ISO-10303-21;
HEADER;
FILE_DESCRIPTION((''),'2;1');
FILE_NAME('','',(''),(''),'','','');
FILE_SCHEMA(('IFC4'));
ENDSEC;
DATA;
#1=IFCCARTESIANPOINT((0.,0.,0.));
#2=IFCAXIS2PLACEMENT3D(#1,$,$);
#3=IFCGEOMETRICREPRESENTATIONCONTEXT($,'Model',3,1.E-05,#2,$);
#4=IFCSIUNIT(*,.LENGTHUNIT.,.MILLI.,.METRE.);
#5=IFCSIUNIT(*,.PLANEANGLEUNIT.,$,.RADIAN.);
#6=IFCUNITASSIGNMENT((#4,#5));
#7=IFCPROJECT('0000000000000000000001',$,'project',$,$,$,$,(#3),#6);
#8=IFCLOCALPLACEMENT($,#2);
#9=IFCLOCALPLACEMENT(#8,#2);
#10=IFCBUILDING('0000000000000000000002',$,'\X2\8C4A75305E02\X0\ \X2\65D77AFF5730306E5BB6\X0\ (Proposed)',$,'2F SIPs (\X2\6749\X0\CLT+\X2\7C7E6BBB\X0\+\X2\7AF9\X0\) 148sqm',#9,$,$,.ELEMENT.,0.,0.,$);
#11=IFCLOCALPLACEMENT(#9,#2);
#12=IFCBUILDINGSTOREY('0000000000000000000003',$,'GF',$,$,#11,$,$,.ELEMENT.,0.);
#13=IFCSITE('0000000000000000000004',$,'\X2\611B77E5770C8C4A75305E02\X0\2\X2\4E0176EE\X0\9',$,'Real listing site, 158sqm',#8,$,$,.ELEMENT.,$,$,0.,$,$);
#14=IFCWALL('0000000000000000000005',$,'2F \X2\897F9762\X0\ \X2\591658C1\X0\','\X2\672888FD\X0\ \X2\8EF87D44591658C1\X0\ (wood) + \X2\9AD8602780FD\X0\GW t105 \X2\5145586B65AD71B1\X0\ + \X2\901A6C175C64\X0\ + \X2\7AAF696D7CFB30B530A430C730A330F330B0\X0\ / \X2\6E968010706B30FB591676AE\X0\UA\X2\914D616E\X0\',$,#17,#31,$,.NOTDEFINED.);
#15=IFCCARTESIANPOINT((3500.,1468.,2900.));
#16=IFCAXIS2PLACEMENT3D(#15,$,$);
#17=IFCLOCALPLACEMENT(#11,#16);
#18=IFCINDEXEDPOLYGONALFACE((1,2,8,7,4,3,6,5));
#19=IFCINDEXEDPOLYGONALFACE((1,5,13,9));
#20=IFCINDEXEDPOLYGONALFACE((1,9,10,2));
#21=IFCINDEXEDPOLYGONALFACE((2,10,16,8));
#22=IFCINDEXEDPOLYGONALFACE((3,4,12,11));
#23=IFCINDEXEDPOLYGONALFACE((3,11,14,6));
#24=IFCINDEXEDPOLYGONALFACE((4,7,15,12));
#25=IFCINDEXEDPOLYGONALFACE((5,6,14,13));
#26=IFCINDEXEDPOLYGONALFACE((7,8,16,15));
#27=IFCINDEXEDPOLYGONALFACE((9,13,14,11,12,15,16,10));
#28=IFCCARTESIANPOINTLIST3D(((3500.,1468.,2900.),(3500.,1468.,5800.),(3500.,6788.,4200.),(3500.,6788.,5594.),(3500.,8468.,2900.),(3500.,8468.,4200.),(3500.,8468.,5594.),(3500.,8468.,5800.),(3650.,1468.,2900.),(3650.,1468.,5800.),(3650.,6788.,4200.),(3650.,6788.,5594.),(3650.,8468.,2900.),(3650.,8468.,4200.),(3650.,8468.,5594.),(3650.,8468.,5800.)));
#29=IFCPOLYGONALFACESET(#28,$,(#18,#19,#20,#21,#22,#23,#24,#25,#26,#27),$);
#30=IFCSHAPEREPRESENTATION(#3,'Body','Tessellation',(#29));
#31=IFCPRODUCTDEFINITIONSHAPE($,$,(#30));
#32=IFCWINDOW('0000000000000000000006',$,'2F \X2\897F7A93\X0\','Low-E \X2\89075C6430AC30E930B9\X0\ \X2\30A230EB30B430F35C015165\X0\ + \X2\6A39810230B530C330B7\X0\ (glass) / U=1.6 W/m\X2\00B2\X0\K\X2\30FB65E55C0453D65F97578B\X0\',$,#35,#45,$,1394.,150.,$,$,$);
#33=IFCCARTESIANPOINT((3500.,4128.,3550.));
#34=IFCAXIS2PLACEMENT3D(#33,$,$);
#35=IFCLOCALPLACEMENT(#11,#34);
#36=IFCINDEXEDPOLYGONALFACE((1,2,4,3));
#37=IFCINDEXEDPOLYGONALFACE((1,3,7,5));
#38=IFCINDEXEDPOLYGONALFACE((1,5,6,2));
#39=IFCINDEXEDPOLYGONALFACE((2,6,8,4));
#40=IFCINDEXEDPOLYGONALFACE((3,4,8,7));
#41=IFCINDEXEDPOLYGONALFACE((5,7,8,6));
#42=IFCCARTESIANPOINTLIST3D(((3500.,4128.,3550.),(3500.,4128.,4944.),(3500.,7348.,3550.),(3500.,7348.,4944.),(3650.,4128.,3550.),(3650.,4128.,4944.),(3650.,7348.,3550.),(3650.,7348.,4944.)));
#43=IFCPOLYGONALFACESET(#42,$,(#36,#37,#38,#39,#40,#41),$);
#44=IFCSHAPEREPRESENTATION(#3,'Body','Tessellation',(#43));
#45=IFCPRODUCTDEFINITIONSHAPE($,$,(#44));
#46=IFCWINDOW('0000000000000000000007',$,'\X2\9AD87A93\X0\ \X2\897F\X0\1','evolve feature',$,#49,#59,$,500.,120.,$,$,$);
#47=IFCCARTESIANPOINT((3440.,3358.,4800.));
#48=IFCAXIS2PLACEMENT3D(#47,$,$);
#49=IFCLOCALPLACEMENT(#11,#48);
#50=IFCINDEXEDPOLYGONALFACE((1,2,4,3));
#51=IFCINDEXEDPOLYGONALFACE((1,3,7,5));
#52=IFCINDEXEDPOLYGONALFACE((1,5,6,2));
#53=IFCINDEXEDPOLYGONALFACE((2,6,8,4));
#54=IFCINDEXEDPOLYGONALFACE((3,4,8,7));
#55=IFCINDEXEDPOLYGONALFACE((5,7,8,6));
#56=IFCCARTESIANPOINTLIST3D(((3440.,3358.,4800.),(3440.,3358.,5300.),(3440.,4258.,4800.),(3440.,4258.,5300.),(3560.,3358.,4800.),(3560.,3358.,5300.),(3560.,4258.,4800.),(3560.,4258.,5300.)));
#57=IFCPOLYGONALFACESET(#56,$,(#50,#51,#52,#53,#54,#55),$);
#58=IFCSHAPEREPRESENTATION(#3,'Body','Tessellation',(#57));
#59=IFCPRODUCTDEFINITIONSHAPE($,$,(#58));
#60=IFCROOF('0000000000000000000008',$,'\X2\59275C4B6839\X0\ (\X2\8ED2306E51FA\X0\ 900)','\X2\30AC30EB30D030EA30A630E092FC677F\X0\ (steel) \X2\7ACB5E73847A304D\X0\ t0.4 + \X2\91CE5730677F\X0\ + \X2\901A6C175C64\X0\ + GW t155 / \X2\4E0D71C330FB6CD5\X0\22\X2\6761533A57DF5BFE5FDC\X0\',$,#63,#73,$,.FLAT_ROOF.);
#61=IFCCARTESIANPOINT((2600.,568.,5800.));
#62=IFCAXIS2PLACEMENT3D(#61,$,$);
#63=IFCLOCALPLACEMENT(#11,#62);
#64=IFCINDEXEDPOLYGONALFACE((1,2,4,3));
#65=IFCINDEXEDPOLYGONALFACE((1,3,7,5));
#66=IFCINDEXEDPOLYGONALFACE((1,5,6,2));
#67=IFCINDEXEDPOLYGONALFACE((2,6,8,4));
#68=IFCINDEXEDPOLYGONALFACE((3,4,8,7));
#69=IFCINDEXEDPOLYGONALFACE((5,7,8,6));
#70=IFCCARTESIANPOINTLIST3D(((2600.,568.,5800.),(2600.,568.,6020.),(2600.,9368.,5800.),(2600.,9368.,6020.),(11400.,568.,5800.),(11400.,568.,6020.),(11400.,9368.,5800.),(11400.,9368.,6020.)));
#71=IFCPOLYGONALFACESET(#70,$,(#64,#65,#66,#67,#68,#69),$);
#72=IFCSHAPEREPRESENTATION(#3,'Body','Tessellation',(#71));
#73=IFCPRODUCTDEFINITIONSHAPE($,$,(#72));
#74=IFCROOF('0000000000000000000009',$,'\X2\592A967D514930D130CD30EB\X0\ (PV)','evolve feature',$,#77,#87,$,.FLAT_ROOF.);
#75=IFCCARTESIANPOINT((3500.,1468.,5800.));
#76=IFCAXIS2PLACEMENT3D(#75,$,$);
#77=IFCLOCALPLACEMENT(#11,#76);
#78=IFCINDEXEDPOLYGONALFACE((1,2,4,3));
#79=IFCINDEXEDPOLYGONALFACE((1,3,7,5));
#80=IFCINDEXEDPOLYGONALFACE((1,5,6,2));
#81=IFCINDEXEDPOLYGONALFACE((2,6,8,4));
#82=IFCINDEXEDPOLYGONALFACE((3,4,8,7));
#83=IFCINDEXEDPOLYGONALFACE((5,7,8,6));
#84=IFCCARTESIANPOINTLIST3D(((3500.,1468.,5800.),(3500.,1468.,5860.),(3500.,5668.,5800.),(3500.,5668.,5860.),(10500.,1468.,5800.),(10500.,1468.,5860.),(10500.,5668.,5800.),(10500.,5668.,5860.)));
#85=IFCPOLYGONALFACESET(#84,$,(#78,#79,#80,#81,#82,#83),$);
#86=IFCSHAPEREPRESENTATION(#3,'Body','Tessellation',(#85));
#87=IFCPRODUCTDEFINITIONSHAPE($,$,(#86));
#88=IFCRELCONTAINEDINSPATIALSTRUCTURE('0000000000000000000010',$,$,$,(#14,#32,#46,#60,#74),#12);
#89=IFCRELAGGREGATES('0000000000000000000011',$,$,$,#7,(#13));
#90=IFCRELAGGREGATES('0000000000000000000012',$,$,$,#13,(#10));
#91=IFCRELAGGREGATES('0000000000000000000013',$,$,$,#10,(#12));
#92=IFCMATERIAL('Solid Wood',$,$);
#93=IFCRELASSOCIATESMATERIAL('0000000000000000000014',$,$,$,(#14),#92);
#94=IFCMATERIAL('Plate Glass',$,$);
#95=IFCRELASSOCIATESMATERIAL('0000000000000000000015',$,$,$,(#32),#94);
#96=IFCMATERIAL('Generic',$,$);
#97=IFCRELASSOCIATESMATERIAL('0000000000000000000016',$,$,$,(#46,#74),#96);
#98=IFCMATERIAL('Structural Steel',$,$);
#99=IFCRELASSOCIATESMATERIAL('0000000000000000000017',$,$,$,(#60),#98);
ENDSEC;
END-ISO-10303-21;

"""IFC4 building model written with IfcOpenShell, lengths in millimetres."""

from ifc_helpers import new_model, si_unit, frame, frame_2d, origin, place, context, project, spatial, rectangle, extrude, material, element, fill, save


model = new_model("IFC4")

# Units and contexts
model_context = context("Model", 3, precision=1e-05, world=origin())
ifc_project = project(units=[si_unit("LENGTHUNIT", "METRE", prefix="MILLI"), si_unit("PLANEANGLEUNIT", "RADIAN")], contexts=[model_context])

# Site, building, storey
site_placement = place(None, origin())
site = spatial("IfcSite", under=ifc_project, at=site_placement, Name="愛知県豊田市2丁目9", ObjectType="Real listing site, 158sqm", CompositionType="ELEMENT", RefElevation=0.0)
building_placement = place(site_placement, origin())
building = spatial("IfcBuilding", under=site, at=building_placement, Name="豊田市 旗竿地の家 (Proposed)", ObjectType="2F SIPs (杉CLT+籾殻+竹) 148sqm", CompositionType="ELEMENT", ElevationOfRefHeight=0.0, ElevationOfTerrain=0.0)
storey_placement = place(building_placement, origin())
storey = spatial("IfcBuildingStorey", under=building, at=storey_placement, Name="GF", CompositionType="ELEMENT", Elevation=0.0)

# Shared definitions
ifc_material_1 = material(Name="Solid Wood")
ifc_material_2 = material(Name="Generic")

# Shared definitions
ifc_material_3 = material(Name="Plate Glass")

# Wall, openings, windows
wall_1_placement = place(storey_placement, frame((3500.0, 1468.0, 2900.0)))
wall_1 = element("IfcWall", 1, at=wall_1_placement, inside=storey, material=ifc_material_1, Name="2F 西面 外壁", Description="木製 軸組外壁 (wood) + 高性能GW t105 充填断熱 + 通気層 + 窯業系サイディング / 準耐火・外皮UA配慮", PredefinedType="NOTDEFINED", context=model_context, shape_type="SweptSolid", body=[
    extrude(rectangle(XDim=150.0, YDim=7000.0, at=frame_2d((75.0, 3500.0))), frame((3500.0, 1468.0, 2900.0)), (0.0, 0.0, 1.0), 2900.0),
])
opening_1_placement = place(storey_placement, frame((3500.0, 4128.0, 3550.0)))
opening_1 = element("IfcOpeningElement", 2, at=opening_1_placement, cuts=wall_1, PredefinedType="NOTDEFINED", context=model_context, shape_type="SweptSolid", body=[
    extrude(rectangle(XDim=150.0, YDim=3220.0, at=frame_2d((75.0, 1610.0))), frame((3500.0, 4128.0, 3550.0)), (0.0, 0.0, 1.0), 1394.0),
])
opening_2_placement = place(storey_placement, frame((3440.0, 3358.0, 4800.0)))
opening_2 = element("IfcOpeningElement", 3, at=opening_2_placement, cuts=wall_1, PredefinedType="NOTDEFINED", context=model_context, shape_type="SweptSolid", body=[
    extrude(rectangle(XDim=120.0, YDim=900.0, at=frame_2d((60.0, 450.0))), frame((3440.0, 3358.0, 4800.0)), (0.0, 0.0, 1.0), 500.0),
])
window_1_placement = place(storey_placement, frame((3500.0, 4128.0, 3550.0)))
window_1 = element("IfcWindow", 4, at=window_1_placement, inside=storey, material=ifc_material_3, Name="2F 西窓", Description="Low-E 複層ガラス アルゴン封入 + 樹脂サッシ (glass) / U=1.6 W/m²K・日射取得型", OverallHeight=1394.0, OverallWidth=150.0, context=model_context, shape_type="SweptSolid", body=[
    extrude(rectangle(XDim=150.0, YDim=3220.0, at=frame_2d((75.0, 1610.0))), frame((3500.0, 4128.0, 3550.0)), (0.0, 0.0, 1.0), 1394.0),
])
fill(opening_1, window_1)
window_2_placement = place(storey_placement, frame((3440.0, 3358.0, 4800.0)))
window_2 = element("IfcWindow", 5, at=window_2_placement, inside=storey, material=ifc_material_2, Name="高窓 西1", Description="evolve feature", OverallHeight=500.0, OverallWidth=120.0, context=model_context, shape_type="SweptSolid", body=[
    extrude(rectangle(XDim=120.0, YDim=900.0, at=frame_2d((60.0, 450.0))), frame((3440.0, 3358.0, 4800.0)), (0.0, 0.0, 1.0), 500.0),
])
fill(opening_2, window_2)

# Roofs
ifc_material_4 = material(Name="Structural Steel")
roof_1_placement = place(storey_placement, frame((2600.0, 568.0, 5800.0)))
element("IfcRoof", 6, at=roof_1_placement, inside=storey, material=ifc_material_4, Name="大屋根 (軒の出 900)", Description="ガルバリウム鋼板 (steel) 立平葺き t0.4 + 野地板 + 通気層 + GW t155 / 不燃・法22条区域対応", PredefinedType="FLAT_ROOF", context=model_context, shape_type="SweptSolid", body=[
    extrude(rectangle(XDim=8800.0, YDim=8800.0, at=frame_2d((4400.0, 4400.0))), frame((2600.0, 568.0, 5800.0)), (0.0, 0.0, 1.0), 220.0),
])
roof_2_placement = place(storey_placement, frame((3500.0, 1468.0, 5800.0)))
element("IfcRoof", 7, at=roof_2_placement, inside=storey, material=ifc_material_2, Name="太陽光パネル (PV)", Description="evolve feature", PredefinedType="FLAT_ROOF", context=model_context, shape_type="SweptSolid", body=[
    extrude(rectangle(XDim=7000.0, YDim=4200.0, at=frame_2d((3500.0, 2100.0))), frame((3500.0, 1468.0, 5800.0)), (0.0, 0.0, 1.0), 60.0),
])

save(model, "model.ifc")
